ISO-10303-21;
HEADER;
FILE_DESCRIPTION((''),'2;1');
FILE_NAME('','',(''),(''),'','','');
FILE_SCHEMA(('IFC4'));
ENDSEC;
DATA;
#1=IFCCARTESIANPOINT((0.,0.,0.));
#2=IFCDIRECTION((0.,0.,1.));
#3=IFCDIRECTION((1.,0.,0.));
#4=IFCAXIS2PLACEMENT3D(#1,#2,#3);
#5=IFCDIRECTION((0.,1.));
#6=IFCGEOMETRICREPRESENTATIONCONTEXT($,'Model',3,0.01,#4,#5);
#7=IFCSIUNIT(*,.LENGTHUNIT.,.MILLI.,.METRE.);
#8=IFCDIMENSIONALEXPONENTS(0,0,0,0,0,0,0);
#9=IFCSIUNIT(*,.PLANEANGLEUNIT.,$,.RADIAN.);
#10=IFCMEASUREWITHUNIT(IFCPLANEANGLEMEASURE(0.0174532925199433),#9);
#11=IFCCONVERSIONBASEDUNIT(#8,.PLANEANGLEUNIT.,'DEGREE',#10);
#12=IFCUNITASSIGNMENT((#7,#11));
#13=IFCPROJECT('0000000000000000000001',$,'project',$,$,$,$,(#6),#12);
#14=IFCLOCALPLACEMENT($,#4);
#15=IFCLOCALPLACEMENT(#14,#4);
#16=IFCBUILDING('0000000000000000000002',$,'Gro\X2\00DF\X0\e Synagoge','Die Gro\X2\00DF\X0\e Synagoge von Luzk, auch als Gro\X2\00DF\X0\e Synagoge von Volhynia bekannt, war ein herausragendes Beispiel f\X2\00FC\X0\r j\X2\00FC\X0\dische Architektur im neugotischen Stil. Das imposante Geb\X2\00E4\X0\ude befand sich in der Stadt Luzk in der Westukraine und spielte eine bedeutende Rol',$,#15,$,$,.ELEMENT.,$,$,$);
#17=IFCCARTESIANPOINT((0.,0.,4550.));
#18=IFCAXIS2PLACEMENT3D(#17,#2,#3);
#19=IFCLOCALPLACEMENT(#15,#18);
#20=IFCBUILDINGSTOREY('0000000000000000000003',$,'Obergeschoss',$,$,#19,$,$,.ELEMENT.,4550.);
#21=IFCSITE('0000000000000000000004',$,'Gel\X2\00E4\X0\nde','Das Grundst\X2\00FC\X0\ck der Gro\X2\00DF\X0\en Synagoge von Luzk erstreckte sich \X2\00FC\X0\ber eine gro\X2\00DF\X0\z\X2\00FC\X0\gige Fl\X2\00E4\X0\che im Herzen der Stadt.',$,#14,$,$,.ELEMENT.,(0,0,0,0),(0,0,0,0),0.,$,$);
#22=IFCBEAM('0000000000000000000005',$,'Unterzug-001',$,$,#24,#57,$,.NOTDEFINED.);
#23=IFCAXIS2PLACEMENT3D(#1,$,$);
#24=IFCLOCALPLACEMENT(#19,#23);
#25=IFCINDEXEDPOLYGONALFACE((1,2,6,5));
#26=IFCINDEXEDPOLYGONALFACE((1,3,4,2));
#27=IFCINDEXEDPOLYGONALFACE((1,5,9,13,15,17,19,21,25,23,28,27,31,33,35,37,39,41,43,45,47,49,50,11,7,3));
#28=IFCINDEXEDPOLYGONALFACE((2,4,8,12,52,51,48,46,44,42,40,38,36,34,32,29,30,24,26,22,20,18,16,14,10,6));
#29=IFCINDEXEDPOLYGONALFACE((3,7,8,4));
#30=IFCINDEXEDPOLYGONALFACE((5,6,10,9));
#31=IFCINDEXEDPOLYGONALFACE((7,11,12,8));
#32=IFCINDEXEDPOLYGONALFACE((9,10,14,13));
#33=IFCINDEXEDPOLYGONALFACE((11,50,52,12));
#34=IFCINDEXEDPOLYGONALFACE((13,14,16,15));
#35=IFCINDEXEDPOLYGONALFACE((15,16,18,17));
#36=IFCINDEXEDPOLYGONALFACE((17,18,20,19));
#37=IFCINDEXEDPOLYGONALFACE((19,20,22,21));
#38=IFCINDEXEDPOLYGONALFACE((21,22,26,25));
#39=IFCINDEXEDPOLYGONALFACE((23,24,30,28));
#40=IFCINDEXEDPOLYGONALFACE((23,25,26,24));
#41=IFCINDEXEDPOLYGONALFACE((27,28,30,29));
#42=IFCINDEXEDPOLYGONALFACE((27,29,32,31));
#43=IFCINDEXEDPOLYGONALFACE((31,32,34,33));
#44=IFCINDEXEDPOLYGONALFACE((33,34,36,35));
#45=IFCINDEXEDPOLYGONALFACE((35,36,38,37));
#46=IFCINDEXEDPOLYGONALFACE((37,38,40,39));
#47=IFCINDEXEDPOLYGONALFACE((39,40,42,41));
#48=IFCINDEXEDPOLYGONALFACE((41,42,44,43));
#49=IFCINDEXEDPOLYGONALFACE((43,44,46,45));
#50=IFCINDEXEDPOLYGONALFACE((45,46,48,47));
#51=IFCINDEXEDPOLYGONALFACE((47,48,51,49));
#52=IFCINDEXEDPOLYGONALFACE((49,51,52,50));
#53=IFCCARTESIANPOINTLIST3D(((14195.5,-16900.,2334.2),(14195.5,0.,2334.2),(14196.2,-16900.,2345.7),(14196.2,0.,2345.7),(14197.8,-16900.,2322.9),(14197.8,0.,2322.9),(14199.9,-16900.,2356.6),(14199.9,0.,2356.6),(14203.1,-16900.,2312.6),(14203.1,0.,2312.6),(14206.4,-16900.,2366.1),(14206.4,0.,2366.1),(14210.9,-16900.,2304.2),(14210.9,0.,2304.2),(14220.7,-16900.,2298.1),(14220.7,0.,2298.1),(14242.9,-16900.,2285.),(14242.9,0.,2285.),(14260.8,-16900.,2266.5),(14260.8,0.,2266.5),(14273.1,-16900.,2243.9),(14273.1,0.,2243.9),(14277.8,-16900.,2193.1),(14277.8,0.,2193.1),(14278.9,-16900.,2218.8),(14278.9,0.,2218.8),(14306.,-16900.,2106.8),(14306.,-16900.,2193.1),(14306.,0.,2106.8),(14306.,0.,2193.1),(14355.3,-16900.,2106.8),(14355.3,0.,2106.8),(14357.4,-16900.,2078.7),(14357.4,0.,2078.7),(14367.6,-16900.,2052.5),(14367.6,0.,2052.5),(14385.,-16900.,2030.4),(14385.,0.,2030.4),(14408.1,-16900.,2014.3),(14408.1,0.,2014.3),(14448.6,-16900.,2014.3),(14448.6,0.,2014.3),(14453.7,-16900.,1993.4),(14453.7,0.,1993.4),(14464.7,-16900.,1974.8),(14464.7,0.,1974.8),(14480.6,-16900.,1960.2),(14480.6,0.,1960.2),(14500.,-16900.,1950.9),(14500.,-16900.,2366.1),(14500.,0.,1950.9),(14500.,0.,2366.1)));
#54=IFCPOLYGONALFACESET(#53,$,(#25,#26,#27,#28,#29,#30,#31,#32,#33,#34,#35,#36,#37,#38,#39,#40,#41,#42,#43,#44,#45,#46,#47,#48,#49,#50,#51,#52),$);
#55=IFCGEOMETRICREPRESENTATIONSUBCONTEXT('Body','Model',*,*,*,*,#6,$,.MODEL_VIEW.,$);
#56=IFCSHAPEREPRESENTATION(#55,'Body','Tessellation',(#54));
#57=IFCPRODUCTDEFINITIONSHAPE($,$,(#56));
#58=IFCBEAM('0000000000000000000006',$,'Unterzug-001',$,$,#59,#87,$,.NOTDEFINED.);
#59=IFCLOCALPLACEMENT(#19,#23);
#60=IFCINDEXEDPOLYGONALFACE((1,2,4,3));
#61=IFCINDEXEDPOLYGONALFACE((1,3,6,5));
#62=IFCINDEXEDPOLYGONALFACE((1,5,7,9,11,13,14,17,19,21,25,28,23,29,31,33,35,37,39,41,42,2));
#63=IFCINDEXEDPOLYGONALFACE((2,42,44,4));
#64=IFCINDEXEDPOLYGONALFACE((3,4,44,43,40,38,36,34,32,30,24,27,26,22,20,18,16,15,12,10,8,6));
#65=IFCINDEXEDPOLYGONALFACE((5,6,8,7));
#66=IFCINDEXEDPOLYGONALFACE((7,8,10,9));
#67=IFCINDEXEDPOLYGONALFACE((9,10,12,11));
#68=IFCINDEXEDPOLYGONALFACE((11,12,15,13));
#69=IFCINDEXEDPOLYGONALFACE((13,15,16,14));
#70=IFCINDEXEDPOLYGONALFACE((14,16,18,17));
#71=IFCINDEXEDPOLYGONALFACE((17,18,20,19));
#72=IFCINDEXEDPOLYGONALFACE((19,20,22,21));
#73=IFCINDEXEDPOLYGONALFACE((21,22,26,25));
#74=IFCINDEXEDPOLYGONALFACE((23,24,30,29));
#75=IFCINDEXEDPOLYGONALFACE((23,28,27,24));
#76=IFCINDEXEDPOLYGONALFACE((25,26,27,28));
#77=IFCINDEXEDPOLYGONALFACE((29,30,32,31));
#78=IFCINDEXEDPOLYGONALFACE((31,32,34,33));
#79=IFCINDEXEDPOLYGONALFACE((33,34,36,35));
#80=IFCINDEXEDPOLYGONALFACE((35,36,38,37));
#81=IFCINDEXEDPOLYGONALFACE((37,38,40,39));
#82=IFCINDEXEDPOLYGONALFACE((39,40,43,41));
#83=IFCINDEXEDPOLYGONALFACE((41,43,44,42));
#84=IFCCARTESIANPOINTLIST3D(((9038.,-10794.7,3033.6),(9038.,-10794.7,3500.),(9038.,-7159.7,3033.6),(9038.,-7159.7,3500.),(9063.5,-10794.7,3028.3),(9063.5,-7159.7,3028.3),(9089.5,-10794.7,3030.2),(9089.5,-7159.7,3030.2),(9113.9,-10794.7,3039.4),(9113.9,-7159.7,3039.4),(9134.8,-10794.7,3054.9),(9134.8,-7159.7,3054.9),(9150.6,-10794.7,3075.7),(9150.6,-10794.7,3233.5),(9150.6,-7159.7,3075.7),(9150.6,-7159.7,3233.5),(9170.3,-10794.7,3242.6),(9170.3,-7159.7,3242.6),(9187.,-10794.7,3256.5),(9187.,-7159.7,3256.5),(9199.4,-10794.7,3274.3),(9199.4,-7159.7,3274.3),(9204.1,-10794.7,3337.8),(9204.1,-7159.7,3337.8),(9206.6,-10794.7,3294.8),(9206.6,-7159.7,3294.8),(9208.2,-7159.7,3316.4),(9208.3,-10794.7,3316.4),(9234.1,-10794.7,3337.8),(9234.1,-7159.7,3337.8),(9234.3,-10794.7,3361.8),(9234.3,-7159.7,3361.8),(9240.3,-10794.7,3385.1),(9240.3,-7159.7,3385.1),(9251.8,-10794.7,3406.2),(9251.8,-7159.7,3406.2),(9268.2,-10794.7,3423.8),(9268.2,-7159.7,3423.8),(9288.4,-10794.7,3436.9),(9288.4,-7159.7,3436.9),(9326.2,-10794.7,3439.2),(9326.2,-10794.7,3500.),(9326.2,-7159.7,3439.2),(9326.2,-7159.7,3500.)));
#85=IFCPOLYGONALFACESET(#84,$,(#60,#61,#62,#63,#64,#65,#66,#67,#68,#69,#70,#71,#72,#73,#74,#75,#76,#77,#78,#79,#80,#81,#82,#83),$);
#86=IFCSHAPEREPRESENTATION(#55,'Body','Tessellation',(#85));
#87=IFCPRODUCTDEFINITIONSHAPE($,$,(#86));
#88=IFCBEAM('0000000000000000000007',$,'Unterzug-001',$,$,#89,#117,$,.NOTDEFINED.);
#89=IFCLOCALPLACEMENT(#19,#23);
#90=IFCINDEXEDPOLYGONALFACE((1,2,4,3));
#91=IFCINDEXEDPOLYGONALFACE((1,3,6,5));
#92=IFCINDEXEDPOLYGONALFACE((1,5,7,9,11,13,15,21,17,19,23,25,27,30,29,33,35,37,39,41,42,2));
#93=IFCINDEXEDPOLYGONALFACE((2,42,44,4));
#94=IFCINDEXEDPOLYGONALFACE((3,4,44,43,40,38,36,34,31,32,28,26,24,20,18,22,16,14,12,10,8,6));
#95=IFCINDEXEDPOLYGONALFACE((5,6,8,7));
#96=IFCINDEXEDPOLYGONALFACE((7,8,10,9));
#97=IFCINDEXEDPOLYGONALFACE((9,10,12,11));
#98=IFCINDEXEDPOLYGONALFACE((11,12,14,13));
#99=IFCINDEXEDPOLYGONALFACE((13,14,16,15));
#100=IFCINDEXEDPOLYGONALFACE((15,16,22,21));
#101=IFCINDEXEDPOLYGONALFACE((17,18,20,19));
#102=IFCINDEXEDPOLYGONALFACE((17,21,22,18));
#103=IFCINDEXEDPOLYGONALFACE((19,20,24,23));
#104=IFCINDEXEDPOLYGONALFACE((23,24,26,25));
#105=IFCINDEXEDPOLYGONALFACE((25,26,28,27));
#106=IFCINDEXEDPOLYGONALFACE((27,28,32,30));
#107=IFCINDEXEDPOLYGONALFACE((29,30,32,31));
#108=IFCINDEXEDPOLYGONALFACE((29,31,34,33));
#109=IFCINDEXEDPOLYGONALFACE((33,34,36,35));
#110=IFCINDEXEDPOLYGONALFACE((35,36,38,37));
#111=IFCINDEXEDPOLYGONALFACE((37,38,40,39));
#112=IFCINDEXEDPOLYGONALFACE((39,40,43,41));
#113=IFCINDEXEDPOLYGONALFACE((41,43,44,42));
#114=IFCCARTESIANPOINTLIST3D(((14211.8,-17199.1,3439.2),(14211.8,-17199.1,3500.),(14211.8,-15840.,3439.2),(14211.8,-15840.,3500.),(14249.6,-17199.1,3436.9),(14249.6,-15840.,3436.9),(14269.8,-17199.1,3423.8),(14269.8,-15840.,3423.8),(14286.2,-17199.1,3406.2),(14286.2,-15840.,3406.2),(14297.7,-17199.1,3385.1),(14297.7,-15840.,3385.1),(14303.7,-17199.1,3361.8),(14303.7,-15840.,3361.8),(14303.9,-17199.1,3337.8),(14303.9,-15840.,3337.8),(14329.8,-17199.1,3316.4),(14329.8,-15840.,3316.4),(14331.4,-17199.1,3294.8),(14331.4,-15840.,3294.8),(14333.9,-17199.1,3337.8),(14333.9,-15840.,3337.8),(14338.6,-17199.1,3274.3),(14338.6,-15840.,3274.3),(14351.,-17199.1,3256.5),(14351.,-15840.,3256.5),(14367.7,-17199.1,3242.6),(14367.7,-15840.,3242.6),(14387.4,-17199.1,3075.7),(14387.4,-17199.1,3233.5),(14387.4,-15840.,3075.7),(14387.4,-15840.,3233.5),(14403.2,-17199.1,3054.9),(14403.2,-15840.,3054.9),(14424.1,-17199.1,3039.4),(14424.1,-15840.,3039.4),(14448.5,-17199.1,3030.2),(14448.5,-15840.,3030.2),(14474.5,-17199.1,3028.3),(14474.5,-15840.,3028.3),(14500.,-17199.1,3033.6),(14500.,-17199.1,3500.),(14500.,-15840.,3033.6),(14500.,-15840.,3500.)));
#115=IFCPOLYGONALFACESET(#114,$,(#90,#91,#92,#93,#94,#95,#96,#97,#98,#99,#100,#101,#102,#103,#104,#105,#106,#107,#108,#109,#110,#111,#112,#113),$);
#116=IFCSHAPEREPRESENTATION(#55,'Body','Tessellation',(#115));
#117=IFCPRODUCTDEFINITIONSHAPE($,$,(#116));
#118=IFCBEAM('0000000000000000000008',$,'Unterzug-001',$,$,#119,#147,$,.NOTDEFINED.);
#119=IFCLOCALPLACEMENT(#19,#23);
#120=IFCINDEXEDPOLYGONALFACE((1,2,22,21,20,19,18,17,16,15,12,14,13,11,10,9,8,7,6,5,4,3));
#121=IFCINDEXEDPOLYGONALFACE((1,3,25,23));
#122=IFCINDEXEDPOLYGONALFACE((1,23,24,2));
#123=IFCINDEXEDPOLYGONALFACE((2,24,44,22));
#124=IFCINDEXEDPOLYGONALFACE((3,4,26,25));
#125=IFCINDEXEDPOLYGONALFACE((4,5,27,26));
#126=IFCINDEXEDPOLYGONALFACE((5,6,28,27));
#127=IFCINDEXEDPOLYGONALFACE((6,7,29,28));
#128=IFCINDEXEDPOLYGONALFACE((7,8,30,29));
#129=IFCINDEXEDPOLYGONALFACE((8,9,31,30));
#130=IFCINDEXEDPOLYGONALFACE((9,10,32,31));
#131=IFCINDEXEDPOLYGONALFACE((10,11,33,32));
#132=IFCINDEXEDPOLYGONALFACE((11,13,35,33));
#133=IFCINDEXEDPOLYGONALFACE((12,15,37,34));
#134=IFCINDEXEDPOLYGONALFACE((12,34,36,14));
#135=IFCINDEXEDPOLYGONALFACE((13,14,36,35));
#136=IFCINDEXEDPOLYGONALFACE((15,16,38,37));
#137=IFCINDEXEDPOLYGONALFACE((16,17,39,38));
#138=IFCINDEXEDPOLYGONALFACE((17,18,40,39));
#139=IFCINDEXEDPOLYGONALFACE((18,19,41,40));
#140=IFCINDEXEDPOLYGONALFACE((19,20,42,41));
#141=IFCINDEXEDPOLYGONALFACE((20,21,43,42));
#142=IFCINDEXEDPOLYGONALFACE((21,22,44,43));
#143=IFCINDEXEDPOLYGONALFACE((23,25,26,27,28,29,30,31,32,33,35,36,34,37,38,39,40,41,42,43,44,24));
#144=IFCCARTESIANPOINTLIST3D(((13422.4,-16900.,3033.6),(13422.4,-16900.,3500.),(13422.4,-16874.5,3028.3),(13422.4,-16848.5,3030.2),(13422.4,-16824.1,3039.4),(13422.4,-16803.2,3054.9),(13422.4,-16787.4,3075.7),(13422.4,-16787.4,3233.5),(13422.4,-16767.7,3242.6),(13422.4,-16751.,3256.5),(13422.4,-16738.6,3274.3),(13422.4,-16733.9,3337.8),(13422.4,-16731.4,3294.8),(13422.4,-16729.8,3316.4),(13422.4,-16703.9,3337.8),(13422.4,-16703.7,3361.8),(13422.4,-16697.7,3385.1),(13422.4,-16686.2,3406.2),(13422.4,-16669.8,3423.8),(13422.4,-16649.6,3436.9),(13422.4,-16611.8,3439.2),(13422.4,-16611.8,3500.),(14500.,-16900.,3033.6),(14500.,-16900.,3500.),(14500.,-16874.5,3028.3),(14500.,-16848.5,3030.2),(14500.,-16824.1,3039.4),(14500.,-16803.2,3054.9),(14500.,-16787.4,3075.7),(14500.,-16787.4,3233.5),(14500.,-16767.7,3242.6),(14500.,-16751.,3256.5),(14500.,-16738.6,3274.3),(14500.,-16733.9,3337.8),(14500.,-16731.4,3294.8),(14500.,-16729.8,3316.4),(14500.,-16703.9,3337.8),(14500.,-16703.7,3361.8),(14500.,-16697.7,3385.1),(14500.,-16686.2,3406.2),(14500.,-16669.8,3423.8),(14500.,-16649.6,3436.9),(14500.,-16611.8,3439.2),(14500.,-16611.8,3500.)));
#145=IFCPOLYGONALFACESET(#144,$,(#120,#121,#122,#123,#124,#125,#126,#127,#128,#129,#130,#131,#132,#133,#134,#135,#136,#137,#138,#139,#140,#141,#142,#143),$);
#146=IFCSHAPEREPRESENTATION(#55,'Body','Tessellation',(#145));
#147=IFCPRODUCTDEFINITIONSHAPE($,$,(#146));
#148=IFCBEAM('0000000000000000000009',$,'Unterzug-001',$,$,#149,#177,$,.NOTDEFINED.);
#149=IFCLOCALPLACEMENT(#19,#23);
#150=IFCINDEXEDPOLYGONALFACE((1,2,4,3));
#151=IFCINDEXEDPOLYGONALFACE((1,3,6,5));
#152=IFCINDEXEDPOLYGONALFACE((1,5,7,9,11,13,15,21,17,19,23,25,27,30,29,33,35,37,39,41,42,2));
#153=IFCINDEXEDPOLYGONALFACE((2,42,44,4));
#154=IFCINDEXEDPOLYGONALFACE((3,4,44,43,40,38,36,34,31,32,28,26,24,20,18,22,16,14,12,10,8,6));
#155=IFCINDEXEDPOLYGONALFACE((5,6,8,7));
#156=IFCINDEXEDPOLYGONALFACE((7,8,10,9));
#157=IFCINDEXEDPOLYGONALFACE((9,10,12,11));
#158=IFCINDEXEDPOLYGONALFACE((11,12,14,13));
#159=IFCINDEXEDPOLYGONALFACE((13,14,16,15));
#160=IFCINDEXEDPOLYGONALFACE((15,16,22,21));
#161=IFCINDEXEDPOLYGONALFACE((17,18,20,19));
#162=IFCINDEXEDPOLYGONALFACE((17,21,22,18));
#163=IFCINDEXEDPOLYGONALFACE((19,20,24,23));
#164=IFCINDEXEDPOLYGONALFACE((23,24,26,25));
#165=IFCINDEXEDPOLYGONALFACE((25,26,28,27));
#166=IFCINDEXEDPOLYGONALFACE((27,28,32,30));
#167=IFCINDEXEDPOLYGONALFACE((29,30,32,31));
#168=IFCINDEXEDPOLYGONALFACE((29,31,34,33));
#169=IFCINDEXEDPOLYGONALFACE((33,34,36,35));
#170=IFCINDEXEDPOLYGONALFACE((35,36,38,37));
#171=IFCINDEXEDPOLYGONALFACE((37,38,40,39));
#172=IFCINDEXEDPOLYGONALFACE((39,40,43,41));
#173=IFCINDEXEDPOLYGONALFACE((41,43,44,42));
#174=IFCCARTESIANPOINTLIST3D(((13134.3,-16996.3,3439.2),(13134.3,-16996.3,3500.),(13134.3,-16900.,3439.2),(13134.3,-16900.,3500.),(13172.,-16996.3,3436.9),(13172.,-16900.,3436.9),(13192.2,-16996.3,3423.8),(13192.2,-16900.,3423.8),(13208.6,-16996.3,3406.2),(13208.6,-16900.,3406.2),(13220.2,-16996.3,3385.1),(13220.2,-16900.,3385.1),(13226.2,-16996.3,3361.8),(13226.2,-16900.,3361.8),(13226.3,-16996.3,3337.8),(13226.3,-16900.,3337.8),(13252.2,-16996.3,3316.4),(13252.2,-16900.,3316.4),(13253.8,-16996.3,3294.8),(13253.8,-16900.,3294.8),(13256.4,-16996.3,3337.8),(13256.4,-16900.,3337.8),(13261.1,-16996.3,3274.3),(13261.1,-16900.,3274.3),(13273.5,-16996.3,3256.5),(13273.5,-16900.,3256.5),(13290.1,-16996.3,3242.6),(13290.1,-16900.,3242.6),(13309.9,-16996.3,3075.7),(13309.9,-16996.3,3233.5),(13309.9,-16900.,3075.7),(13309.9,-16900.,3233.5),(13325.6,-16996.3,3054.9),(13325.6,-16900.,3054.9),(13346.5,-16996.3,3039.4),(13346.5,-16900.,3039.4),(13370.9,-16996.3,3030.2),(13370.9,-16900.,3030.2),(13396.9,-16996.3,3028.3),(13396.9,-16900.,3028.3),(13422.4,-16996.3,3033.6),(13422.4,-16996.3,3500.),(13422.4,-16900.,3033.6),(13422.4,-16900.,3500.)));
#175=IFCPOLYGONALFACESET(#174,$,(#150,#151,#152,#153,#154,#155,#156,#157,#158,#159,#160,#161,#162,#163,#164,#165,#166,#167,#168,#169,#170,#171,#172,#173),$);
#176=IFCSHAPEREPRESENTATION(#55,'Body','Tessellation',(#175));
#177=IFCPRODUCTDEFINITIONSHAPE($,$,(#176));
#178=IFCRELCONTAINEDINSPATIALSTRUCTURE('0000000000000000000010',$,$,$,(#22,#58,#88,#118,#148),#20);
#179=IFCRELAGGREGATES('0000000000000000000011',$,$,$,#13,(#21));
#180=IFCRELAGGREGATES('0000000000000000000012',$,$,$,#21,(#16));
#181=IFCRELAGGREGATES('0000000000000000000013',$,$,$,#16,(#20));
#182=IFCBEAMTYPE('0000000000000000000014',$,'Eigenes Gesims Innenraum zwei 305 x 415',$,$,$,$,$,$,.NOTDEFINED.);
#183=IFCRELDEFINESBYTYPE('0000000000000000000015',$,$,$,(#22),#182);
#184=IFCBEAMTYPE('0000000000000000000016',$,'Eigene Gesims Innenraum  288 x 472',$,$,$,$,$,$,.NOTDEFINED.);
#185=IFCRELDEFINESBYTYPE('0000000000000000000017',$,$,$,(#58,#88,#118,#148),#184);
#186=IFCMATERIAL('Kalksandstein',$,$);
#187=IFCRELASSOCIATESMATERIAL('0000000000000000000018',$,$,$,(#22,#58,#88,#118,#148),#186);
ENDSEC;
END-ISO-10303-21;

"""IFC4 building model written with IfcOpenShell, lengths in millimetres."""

from ifc_helpers import new_model, entity, si_unit, converted_unit, direction, frame, origin_with_axes, place, context, subcontext, project, spatial, line, arc, indexed_curve, outline, extrude, material, material_profile, profile_set, type_object, element, save


model = new_model("IFC4")

# Units and contexts
model_context = context("Model", 3, precision=0.01, world=origin_with_axes(), true_north=direction((0.0, 1.0)))
body_context = subcontext(model_context, "Body", "Model", "MODEL_VIEW")
ifc_project = project(units=[si_unit("LENGTHUNIT", "METRE", prefix="MILLI"), converted_unit("PLANEANGLEUNIT", "DEGREE", entity("IfcPlaneAngleMeasure", 0.0174532925199433), si_unit("PLANEANGLEUNIT", "RADIAN"), dimensions=[0, 0, 0, 0, 0, 0, 0])], contexts=[model_context])

# Site, building, storey
site_placement = place(None, origin_with_axes())
site = spatial("IfcSite", under=ifc_project, at=site_placement, Name="Gelände", Description="Das Grundstück der Großen Synagoge von Luzk erstreckte sich über eine großzügige Fläche im Herzen der Stadt.", CompositionType="ELEMENT", RefLatitude=(0, 0, 0, 0), RefLongitude=(0, 0, 0, 0), RefElevation=0.0)
building_placement = place(site_placement, origin_with_axes())
building = spatial("IfcBuilding", under=site, at=building_placement, Name="Große Synagoge", Description="Die Große Synagoge von Luzk, auch als Große Synagoge von Volhynia bekannt, war ein herausragendes Beispiel für jüdische Architektur im neugotischen Stil. Das imposante Gebäude befand sich in der Stadt Luzk in der Westukraine und spielte eine bedeutende Rol", CompositionType="ELEMENT")
storey_placement = place(building_placement, frame((0.0, 0.0, 4550.0), z_axis=(0.0, 0.0, 1.0), x_axis=(1.0, 0.0, 0.0)))
storey = spatial("IfcBuildingStorey", under=building, at=storey_placement, Name="Obergeschoss", CompositionType="ELEMENT", Elevation=4550.0)

# Beams
ifc_material_1 = material(Name="Kalksandstein")
ifc_material_profile_1 = material_profile(ifc_material_1, outline(indexed_curve([(194.0, -173.0), (222.2, -173.0), (232.3, -110.5), (279.3, -68.0), (303.7, -37.6), (293.6, 0.0), (0.0, 0.0), (0.0, -415.2), (35.3, -391.3), (51.4, -351.7), (91.9, -351.7), (132.4, -313.6), (144.7, -259.3), (194.0, -259.3)], segments=[line(1, 2), arc(2, 3, 4), arc(4, 5, 6), line(6, 7, 8), arc(8, 9, 10), line(10, 11), arc(11, 12, 13), line(13, 14, 1)])), Name="Kalksandstein")
ifc_profile_set_1 = profile_set([ifc_material_profile_1], Name="Eigenes Gesims Innenraum zwei")
beam_type_1 = type_object("IfcBeamType", Name="Eigenes Gesims Innenraum zwei 305 x 415", PredefinedType="NOTDEFINED")
beam_1_placement = place(storey_placement, frame((14500.0, -16900.0, 2366.1), z_axis=(0.0, 0.0, 1.0), x_axis=(1.0, 0.0, 0.0)))
element("IfcBeam", 1, at=beam_1_placement, inside=storey, type_object=beam_type_1, material=ifc_profile_set_1, Name="Unterzug-001", PredefinedType="NOTDEFINED", context=body_context, shape_type="SweptSolid", body=[
    extrude(outline(indexed_curve([(194.0, -173.0), (222.2, -173.0), (232.3, -110.5), (279.3, -68.0), (303.7, -37.6), (293.6, 0.0), (0.0, 0.0), (0.0, -415.2), (35.3, -391.3), (51.4, -351.7), (91.9, -351.7), (132.4, -313.6), (144.7, -259.3), (194.0, -259.3)], segments=[line(1, 2), arc(2, 3, 4), arc(4, 5, 6), line(6, 7, 8), arc(8, 9, 10), line(10, 11), arc(11, 12, 13), line(13, 14, 1)])), frame((0.0, 16900.0, 0.0), z_axis=(0.0, 1.0, 0.0), x_axis=(-1.0, 0.0, 0.0)), (0.0, 0.0, -1.0), 16900.0),
])
ifc_material_profile_2 = material_profile(ifc_material_1, outline(indexed_curve([(0.0, 0.0), (0.0, -466.4), (64.0, -466.1), (112.6, -424.3), (112.6, -266.5), (161.4, -225.7), (166.1, -162.2), (196.1, -162.2), (207.4, -104.0), (250.4, -63.1), (288.2, -60.8), (288.2, 0.0)], segments=[line(1, 2), arc(2, 3, 4), line(4, 5), arc(5, 6, 7), line(7, 8), arc(8, 9, 10), line(10, 11, 12, 1)])), Name="Kalksandstein")
ifc_profile_set_2 = profile_set([ifc_material_profile_2], Name="Eigene Gesims Innenraum ")
beam_type_2 = type_object("IfcBeamType", Name="Eigene Gesims Innenraum  288 x 472", PredefinedType="NOTDEFINED")
beam_2_placement = place(storey_placement, frame((9038.0, -10794.7, 3500.0), z_axis=(0.0, 0.0, 1.0), x_axis=(1.0, 0.000001, 0.0)))
element("IfcBeam", 2, at=beam_2_placement, inside=storey, type_object=beam_type_2, material=ifc_profile_set_2, Name="Unterzug-001", PredefinedType="NOTDEFINED", context=body_context, shape_type="SweptSolid", body=[
    extrude(outline(indexed_curve([(0.0, 0.0), (0.0, -466.4), (64.0, -466.1), (112.6, -424.3), (112.6, -266.5), (161.4, -225.7), (166.1, -162.2), (196.1, -162.2), (207.4, -104.0), (250.4, -63.1), (288.2, -60.8), (288.2, 0.0)], segments=[line(1, 2), arc(2, 3, 4), line(4, 5), arc(5, 6, 7), line(7, 8), arc(8, 9, 10), line(10, 11, 12, 1)])), frame((0.0, 3635.0, 0.0), z_axis=(0.0, -1.0, 0.0), x_axis=(1.0, 0.0, 0.0)), (0.0, 0.0, 1.0), 3635.0),
])
beam_3_placement = place(storey_placement, frame((14500.0, -17199.1, 3500.0), z_axis=(0.0, 0.0, 1.0), x_axis=(1.0, 0.0, 0.0)))
element("IfcBeam", 3, at=beam_3_placement, inside=storey, type_object=beam_type_2, material=ifc_profile_set_2, Name="Unterzug-001", PredefinedType="NOTDEFINED", context=body_context, shape_type="SweptSolid", body=[
    extrude(outline(indexed_curve([(0.0, 0.0), (0.0, -466.4), (64.0, -466.1), (112.6, -424.3), (112.6, -266.5), (161.4, -225.7), (166.1, -162.2), (196.1, -162.2), (207.4, -104.0), (250.4, -63.1), (288.2, -60.8), (288.2, 0.0)], segments=[line(1, 2), arc(2, 3, 4), line(4, 5), arc(5, 6, 7), line(7, 8), arc(8, 9, 10), line(10, 11, 12, 1)])), frame((0.0, 1359.2, 0.0), z_axis=(0.0, 1.0, 0.0), x_axis=(-1.0, 0.0, 0.0)), (0.0, 0.0, -1.0), 1359.2),
])
beam_4_placement = place(storey_placement, frame((13422.4, -16900.0, 3500.0), z_axis=(0.0, 0.0, 1.0), x_axis=(0.0, -1.0, 0.0)))
element("IfcBeam", 4, at=beam_4_placement, inside=storey, type_object=beam_type_2, material=ifc_profile_set_2, Name="Unterzug-001", PredefinedType="NOTDEFINED", context=body_context, shape_type="SweptSolid", body=[
    extrude(outline(indexed_curve([(0.0, 0.0), (0.0, -466.4), (64.0, -466.1), (112.6, -424.3), (112.6, -266.5), (161.4, -225.7), (166.1, -162.2), (196.1, -162.2), (207.4, -104.0), (250.4, -63.1), (288.2, -60.8), (288.2, 0.0)], segments=[line(1, 2), arc(2, 3, 4), line(4, 5), arc(5, 6, 7), line(7, 8), arc(8, 9, 10), line(10, 11, 12, 1)])), frame((0.0, 1077.6, 0.0), z_axis=(0.0, 1.0, 0.0), x_axis=(-1.0, 0.0, 0.0)), (0.0, 0.0, -1.0), 1077.6),
])
beam_5_placement = place(storey_placement, frame((13422.4, -16996.3, 3500.0), z_axis=(0.0, 0.0, 1.0), x_axis=(1.0, 0.0, 0.0)))
element("IfcBeam", 5, at=beam_5_placement, inside=storey, type_object=beam_type_2, material=ifc_profile_set_2, Name="Unterzug-001", PredefinedType="NOTDEFINED", context=body_context, shape_type="SweptSolid", body=[
    extrude(outline(indexed_curve([(0.0, 0.0), (0.0, -466.4), (64.0, -466.1), (112.6, -424.3), (112.6, -266.5), (161.4, -225.7), (166.1, -162.2), (196.1, -162.2), (207.4, -104.0), (250.4, -63.1), (288.2, -60.8), (288.2, 0.0)], segments=[line(1, 2), arc(2, 3, 4), line(4, 5), arc(5, 6, 7), line(7, 8), arc(8, 9, 10), line(10, 11, 12, 1)])), frame((0.0, 96.3, 0.0), z_axis=(0.0, 1.0, 0.0), x_axis=(-1.0, 0.0, 0.0)), (0.0, 0.0, -1.0), 96.3),
])

save(model, "model.ifc")
